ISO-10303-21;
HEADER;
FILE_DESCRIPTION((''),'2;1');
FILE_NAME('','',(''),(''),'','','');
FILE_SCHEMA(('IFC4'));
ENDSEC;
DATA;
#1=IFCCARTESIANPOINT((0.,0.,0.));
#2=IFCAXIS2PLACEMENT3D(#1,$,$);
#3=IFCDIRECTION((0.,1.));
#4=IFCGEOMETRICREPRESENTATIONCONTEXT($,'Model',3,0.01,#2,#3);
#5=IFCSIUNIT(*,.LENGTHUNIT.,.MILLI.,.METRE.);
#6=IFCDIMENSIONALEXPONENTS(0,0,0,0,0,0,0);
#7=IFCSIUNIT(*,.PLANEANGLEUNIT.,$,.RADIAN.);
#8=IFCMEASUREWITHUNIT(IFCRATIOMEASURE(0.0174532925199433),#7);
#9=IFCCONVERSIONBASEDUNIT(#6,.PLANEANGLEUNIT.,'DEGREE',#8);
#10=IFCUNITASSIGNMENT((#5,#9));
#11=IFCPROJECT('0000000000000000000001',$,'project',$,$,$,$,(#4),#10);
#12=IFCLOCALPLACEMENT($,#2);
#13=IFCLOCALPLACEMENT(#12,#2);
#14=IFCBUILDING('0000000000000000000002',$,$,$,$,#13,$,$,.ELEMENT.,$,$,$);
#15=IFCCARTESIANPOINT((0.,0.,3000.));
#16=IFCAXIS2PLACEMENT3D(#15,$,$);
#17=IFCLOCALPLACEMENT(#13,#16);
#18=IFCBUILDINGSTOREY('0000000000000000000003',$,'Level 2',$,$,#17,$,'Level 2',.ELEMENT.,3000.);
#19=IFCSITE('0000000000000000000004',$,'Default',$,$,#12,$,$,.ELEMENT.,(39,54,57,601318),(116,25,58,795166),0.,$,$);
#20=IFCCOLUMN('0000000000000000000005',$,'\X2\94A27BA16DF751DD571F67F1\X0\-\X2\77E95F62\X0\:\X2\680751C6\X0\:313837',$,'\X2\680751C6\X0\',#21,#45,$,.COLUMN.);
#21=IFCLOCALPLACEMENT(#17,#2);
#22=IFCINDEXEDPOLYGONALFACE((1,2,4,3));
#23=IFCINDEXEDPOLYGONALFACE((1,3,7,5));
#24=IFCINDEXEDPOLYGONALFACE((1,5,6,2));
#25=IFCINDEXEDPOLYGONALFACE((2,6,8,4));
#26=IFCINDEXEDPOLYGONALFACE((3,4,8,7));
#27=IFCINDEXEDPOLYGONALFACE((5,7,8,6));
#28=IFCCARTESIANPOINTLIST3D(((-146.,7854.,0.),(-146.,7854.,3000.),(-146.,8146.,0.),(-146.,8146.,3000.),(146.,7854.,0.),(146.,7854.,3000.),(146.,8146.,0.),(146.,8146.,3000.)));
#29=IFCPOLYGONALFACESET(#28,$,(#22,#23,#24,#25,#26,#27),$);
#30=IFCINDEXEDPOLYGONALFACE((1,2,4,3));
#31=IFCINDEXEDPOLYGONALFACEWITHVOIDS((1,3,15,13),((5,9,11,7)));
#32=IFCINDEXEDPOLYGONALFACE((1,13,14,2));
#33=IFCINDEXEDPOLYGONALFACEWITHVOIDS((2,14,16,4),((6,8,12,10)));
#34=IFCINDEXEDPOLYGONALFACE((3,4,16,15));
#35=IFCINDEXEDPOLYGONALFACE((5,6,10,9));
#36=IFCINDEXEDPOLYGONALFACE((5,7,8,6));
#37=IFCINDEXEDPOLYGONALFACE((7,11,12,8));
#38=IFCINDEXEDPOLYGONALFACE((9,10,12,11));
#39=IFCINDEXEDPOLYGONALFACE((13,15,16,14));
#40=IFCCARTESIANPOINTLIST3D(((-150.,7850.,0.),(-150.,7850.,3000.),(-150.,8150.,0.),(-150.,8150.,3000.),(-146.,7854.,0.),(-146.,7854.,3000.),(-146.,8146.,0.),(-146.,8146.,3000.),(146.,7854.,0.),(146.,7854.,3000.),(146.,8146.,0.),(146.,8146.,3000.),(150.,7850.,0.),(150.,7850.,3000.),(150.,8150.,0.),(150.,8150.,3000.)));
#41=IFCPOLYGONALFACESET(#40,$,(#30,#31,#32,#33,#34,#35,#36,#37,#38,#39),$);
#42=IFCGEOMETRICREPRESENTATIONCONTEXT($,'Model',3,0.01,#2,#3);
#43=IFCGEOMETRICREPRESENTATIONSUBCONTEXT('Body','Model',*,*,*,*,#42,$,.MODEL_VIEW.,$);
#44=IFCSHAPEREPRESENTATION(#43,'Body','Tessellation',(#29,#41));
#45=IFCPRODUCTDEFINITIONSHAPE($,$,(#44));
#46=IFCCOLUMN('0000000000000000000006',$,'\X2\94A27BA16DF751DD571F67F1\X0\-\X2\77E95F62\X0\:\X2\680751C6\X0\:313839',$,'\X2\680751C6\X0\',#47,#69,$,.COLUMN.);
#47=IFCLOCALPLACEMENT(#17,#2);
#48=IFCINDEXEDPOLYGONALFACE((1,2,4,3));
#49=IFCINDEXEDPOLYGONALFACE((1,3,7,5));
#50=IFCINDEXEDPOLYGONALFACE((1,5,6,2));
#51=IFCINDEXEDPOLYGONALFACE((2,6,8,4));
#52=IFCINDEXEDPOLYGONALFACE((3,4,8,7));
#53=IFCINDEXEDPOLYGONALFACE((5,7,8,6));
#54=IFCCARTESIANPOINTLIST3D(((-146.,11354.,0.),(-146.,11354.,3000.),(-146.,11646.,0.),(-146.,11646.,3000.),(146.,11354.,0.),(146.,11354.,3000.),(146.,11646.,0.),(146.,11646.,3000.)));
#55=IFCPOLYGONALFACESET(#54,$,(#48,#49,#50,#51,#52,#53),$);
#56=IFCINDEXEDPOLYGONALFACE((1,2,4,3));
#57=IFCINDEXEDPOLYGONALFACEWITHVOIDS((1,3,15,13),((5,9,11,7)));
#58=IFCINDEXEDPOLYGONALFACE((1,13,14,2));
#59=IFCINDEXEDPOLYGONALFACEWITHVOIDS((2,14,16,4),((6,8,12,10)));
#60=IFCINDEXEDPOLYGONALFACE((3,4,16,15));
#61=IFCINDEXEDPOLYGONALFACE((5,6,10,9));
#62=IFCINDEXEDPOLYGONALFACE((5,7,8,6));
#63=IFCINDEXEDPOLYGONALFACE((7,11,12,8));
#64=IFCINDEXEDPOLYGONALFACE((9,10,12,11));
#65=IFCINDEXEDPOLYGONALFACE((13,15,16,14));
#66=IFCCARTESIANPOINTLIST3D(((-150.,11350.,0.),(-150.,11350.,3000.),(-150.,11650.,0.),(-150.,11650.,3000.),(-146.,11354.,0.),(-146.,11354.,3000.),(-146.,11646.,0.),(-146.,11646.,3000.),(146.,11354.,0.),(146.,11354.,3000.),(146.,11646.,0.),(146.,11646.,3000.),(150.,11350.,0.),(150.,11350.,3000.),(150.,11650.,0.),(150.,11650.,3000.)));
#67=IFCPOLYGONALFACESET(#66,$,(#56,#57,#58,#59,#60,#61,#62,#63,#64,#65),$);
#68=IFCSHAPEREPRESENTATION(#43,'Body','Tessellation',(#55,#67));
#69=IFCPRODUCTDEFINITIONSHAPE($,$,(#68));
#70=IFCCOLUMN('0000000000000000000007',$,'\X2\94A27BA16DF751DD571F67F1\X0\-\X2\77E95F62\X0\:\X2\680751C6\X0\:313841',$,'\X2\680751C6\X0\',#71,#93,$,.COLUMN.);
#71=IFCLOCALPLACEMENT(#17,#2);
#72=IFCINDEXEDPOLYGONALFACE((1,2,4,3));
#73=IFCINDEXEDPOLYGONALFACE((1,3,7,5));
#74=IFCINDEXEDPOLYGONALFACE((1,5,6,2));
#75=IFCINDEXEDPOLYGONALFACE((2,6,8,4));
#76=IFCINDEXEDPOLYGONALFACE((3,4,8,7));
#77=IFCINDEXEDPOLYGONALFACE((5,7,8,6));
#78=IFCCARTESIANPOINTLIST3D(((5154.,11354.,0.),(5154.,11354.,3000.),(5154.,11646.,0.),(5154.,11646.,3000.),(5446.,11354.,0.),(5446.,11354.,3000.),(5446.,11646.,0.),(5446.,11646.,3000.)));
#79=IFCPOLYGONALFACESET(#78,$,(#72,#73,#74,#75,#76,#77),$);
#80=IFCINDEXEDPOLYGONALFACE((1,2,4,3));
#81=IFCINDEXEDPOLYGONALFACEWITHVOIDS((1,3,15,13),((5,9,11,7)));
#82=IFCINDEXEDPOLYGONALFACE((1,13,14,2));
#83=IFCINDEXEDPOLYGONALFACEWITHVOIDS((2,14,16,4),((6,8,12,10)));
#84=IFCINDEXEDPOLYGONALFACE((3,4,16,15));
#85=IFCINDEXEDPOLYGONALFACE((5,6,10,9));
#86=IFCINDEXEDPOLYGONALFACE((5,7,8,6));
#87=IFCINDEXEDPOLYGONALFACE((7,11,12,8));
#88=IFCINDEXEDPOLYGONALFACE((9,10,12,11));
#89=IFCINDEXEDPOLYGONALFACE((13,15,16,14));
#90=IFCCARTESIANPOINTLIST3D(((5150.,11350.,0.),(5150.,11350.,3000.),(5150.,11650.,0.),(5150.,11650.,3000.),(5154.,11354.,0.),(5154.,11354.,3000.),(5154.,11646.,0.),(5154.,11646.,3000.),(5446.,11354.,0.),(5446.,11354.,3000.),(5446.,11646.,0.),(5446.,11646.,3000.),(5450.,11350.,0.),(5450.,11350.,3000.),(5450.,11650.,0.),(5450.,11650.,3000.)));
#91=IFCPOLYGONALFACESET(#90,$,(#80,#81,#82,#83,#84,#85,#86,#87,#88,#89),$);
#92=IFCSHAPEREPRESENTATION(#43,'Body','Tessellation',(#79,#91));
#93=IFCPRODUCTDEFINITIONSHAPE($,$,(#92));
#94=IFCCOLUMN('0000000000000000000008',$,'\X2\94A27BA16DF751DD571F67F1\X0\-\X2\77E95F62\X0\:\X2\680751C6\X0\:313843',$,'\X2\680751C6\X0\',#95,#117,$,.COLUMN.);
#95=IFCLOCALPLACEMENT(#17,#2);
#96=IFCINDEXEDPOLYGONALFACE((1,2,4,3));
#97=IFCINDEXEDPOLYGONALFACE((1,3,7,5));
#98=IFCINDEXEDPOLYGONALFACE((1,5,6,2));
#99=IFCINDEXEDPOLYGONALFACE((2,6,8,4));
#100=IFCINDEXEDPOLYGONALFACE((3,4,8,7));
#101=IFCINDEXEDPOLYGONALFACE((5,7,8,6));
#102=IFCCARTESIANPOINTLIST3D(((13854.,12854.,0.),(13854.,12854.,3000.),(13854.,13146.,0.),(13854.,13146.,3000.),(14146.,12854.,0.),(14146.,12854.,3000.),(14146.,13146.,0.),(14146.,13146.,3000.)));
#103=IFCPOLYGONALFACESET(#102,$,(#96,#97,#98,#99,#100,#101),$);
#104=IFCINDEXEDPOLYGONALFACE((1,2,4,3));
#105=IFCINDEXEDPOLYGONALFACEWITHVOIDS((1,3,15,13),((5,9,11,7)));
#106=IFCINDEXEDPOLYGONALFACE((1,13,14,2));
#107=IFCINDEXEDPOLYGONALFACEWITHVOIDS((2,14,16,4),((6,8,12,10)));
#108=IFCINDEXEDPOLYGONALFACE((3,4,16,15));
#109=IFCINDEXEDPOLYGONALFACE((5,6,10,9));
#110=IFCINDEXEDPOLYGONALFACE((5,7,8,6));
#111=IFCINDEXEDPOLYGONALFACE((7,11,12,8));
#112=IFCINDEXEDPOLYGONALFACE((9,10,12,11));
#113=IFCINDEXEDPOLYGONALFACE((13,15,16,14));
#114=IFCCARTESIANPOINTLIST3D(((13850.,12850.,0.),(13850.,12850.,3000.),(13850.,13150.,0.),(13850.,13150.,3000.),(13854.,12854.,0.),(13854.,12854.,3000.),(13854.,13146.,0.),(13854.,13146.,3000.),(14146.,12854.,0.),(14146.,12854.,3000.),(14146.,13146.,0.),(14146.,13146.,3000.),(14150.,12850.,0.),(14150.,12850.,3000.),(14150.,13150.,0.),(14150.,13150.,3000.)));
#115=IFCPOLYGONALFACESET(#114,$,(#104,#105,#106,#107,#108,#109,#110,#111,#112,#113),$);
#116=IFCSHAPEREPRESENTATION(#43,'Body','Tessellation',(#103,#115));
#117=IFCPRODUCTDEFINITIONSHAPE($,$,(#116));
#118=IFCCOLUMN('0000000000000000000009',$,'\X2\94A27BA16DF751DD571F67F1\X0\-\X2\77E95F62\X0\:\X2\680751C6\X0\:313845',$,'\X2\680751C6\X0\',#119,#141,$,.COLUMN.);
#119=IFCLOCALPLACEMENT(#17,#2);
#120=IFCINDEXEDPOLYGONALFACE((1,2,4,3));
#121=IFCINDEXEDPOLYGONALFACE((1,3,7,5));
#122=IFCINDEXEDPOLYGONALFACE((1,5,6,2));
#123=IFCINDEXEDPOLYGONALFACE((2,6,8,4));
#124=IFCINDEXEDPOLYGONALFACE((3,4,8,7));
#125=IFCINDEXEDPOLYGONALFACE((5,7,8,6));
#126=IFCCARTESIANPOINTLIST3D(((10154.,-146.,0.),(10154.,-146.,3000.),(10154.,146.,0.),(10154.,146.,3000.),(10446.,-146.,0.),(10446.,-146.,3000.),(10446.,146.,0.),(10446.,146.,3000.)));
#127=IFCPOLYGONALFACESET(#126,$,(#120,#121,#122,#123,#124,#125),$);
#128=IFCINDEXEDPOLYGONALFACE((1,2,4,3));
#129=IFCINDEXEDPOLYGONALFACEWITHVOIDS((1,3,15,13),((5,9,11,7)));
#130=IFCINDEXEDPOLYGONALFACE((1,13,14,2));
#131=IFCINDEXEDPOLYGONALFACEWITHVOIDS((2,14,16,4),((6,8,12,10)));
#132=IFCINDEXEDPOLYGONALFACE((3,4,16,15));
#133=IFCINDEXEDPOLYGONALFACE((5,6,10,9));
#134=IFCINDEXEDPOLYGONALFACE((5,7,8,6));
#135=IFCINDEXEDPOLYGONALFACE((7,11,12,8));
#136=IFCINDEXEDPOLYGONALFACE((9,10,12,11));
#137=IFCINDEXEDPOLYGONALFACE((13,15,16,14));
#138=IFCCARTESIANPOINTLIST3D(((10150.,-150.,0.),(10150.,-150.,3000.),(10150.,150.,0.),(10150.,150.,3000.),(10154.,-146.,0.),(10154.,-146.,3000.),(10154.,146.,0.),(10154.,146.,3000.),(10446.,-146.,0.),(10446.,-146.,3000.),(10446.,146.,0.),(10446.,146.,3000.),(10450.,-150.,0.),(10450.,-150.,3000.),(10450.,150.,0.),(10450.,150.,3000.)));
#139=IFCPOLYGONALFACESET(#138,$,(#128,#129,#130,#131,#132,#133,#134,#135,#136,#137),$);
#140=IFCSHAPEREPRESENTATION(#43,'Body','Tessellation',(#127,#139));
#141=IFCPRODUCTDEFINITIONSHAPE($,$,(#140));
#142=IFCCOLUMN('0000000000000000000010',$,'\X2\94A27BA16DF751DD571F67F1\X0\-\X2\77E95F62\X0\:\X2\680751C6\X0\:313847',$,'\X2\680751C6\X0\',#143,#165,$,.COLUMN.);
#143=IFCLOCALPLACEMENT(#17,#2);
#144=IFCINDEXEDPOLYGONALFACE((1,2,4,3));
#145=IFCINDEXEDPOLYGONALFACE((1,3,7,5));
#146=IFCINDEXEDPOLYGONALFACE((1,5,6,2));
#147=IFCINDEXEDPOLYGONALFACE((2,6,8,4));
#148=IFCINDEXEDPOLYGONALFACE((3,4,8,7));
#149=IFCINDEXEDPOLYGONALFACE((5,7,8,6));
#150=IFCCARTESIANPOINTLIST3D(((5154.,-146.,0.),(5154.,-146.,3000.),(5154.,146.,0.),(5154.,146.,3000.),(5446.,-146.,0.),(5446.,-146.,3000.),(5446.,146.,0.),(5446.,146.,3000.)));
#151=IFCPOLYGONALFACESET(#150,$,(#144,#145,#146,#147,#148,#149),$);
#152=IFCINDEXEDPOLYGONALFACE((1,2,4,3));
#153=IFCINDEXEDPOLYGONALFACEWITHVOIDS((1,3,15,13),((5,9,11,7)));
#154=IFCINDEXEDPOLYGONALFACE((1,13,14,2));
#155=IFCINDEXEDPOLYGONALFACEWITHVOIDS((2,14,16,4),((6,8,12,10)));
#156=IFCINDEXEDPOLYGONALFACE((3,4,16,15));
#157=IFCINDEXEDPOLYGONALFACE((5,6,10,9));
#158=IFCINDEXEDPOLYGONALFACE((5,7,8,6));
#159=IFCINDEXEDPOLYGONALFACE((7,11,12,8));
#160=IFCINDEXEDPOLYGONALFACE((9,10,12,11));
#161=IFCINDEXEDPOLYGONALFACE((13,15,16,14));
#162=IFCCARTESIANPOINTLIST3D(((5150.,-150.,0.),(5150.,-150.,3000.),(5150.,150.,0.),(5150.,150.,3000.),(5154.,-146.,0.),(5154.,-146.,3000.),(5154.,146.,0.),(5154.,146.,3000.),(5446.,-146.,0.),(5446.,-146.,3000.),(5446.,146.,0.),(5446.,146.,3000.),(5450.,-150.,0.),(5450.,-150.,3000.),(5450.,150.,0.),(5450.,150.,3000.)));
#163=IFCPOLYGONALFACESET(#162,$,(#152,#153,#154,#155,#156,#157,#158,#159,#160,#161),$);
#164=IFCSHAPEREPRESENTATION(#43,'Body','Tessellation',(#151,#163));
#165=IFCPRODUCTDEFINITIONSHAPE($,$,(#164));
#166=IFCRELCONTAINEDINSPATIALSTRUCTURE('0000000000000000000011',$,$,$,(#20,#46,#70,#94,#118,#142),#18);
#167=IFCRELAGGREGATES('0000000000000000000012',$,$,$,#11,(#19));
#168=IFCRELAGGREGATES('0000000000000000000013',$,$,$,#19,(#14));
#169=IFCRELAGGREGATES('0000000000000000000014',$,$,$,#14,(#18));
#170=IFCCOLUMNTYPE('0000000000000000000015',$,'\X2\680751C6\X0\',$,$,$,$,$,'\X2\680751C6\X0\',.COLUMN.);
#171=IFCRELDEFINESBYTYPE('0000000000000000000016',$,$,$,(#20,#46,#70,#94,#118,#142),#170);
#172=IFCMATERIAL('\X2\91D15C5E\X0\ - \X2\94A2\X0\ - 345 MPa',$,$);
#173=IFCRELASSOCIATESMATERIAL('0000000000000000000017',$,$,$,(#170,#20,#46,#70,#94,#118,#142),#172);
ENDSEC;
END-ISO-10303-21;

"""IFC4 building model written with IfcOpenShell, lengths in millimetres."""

from ifc_helpers import new_model, entity, si_unit, converted_unit, direction, frame, origin, origin_2d_with_axis, place, context, subcontext, project, spatial, polyline, rectangle, outline, extrude, source, transform, mapped, material, type_object, type_shapes, element, save


model = new_model("IFC4")

# Units and contexts
model_context_1 = context("Model", 3, precision=0.01, world=origin(), true_north=direction((0.0, 1.0)))
model_context_2 = context("Model", 3, precision=0.01, world=origin(), true_north=direction((0.0, 1.0)))
body_context = subcontext(model_context_2, "Body", "Model", "MODEL_VIEW")
ifc_project = project(units=[si_unit("LENGTHUNIT", "METRE", prefix="MILLI"), converted_unit("PLANEANGLEUNIT", "DEGREE", entity("IfcRatioMeasure", 0.0174532925199433), si_unit("PLANEANGLEUNIT", "RADIAN"), dimensions=[0, 0, 0, 0, 0, 0, 0])], contexts=[model_context_1])

# Site, building, storey
site_placement = place(None, origin())
site = spatial("IfcSite", under=ifc_project, at=site_placement, Name="Default", CompositionType="ELEMENT", RefLatitude=(39, 54, 57, 601318), RefLongitude=(116, 25, 58, 795166), RefElevation=0.0)
building_placement = place(site_placement, origin())
building = spatial("IfcBuilding", under=site, at=building_placement, CompositionType="ELEMENT")
storey_placement = place(building_placement, frame((0.0, 0.0, 3000.0)))
storey = spatial("IfcBuildingStorey", under=building, at=storey_placement, Name="Level 2", LongName="Level 2", CompositionType="ELEMENT", Elevation=3000.0)

# Columns
ifc_material = material(Name="金属 - 钢 - 345 MPa")
column_type = type_object("IfcColumnType", Name="标准", ElementType="标准", PredefinedType="COLUMN", material=ifc_material)
shared_shape = source(origin(), body_context, "Body", "SweptSolid", [
    extrude(rectangle(XDim=292.0, YDim=292.0, at=origin_2d_with_axis()), frame((150.0, 150.0, 0.0), z_axis=(0.0, 0.0, 1.0), x_axis=(-1.0, 0.0, 0.0)), (0.0, 0.0, 1.0), 3000.0),
    extrude(outline(polyline([(-150.0, -150.0), (150.0, -150.0), (150.0, 150.0), (-150.0, 150.0), (-150.0, -150.0)]), holes=[polyline([(-146.0, -146.0), (-146.0, 146.0), (146.0, 146.0), (146.0, -146.0), (-146.0, -146.0)])]), frame((150.0, 150.0, 0.0), z_axis=(0.0, 0.0, 1.0), x_axis=(-1.0, 0.0, 0.0)), (0.0, 0.0, 1.0), 3000.0),
])
type_shapes(column_type, [shared_shape])
for number, where, name in (
    (1, (-150.0, 7850.0, 0.0), "钢管混凝土柱-矩形:标准:313837"),
    (2, (-150.0, 11350.0, 0.0), "钢管混凝土柱-矩形:标准:313839"),
    (3, (5150.0, 11350.0, 0.0), "钢管混凝土柱-矩形:标准:313841"),
    (4, (13850.0, 12850.0, 0.0), "钢管混凝土柱-矩形:标准:313843"),
    (5, (10150.0, -150.0, 0.0), "钢管混凝土柱-矩形:标准:313845"),
    (6, (5150.0, -150.0, 0.0), "钢管混凝土柱-矩形:标准:313847"),
):
    element("IfcColumn", number, at=place(storey_placement, frame(where)), inside=storey, type_object=column_type, material=ifc_material, Name=name, ObjectType="标准", PredefinedType="COLUMN", context=body_context, shape_type="MappedRepresentation", body=[
        mapped(shared_shape, transform((0.0, 0.0, 0.0), scale=1.0)),
    ])

save(model, "model.ifc")
